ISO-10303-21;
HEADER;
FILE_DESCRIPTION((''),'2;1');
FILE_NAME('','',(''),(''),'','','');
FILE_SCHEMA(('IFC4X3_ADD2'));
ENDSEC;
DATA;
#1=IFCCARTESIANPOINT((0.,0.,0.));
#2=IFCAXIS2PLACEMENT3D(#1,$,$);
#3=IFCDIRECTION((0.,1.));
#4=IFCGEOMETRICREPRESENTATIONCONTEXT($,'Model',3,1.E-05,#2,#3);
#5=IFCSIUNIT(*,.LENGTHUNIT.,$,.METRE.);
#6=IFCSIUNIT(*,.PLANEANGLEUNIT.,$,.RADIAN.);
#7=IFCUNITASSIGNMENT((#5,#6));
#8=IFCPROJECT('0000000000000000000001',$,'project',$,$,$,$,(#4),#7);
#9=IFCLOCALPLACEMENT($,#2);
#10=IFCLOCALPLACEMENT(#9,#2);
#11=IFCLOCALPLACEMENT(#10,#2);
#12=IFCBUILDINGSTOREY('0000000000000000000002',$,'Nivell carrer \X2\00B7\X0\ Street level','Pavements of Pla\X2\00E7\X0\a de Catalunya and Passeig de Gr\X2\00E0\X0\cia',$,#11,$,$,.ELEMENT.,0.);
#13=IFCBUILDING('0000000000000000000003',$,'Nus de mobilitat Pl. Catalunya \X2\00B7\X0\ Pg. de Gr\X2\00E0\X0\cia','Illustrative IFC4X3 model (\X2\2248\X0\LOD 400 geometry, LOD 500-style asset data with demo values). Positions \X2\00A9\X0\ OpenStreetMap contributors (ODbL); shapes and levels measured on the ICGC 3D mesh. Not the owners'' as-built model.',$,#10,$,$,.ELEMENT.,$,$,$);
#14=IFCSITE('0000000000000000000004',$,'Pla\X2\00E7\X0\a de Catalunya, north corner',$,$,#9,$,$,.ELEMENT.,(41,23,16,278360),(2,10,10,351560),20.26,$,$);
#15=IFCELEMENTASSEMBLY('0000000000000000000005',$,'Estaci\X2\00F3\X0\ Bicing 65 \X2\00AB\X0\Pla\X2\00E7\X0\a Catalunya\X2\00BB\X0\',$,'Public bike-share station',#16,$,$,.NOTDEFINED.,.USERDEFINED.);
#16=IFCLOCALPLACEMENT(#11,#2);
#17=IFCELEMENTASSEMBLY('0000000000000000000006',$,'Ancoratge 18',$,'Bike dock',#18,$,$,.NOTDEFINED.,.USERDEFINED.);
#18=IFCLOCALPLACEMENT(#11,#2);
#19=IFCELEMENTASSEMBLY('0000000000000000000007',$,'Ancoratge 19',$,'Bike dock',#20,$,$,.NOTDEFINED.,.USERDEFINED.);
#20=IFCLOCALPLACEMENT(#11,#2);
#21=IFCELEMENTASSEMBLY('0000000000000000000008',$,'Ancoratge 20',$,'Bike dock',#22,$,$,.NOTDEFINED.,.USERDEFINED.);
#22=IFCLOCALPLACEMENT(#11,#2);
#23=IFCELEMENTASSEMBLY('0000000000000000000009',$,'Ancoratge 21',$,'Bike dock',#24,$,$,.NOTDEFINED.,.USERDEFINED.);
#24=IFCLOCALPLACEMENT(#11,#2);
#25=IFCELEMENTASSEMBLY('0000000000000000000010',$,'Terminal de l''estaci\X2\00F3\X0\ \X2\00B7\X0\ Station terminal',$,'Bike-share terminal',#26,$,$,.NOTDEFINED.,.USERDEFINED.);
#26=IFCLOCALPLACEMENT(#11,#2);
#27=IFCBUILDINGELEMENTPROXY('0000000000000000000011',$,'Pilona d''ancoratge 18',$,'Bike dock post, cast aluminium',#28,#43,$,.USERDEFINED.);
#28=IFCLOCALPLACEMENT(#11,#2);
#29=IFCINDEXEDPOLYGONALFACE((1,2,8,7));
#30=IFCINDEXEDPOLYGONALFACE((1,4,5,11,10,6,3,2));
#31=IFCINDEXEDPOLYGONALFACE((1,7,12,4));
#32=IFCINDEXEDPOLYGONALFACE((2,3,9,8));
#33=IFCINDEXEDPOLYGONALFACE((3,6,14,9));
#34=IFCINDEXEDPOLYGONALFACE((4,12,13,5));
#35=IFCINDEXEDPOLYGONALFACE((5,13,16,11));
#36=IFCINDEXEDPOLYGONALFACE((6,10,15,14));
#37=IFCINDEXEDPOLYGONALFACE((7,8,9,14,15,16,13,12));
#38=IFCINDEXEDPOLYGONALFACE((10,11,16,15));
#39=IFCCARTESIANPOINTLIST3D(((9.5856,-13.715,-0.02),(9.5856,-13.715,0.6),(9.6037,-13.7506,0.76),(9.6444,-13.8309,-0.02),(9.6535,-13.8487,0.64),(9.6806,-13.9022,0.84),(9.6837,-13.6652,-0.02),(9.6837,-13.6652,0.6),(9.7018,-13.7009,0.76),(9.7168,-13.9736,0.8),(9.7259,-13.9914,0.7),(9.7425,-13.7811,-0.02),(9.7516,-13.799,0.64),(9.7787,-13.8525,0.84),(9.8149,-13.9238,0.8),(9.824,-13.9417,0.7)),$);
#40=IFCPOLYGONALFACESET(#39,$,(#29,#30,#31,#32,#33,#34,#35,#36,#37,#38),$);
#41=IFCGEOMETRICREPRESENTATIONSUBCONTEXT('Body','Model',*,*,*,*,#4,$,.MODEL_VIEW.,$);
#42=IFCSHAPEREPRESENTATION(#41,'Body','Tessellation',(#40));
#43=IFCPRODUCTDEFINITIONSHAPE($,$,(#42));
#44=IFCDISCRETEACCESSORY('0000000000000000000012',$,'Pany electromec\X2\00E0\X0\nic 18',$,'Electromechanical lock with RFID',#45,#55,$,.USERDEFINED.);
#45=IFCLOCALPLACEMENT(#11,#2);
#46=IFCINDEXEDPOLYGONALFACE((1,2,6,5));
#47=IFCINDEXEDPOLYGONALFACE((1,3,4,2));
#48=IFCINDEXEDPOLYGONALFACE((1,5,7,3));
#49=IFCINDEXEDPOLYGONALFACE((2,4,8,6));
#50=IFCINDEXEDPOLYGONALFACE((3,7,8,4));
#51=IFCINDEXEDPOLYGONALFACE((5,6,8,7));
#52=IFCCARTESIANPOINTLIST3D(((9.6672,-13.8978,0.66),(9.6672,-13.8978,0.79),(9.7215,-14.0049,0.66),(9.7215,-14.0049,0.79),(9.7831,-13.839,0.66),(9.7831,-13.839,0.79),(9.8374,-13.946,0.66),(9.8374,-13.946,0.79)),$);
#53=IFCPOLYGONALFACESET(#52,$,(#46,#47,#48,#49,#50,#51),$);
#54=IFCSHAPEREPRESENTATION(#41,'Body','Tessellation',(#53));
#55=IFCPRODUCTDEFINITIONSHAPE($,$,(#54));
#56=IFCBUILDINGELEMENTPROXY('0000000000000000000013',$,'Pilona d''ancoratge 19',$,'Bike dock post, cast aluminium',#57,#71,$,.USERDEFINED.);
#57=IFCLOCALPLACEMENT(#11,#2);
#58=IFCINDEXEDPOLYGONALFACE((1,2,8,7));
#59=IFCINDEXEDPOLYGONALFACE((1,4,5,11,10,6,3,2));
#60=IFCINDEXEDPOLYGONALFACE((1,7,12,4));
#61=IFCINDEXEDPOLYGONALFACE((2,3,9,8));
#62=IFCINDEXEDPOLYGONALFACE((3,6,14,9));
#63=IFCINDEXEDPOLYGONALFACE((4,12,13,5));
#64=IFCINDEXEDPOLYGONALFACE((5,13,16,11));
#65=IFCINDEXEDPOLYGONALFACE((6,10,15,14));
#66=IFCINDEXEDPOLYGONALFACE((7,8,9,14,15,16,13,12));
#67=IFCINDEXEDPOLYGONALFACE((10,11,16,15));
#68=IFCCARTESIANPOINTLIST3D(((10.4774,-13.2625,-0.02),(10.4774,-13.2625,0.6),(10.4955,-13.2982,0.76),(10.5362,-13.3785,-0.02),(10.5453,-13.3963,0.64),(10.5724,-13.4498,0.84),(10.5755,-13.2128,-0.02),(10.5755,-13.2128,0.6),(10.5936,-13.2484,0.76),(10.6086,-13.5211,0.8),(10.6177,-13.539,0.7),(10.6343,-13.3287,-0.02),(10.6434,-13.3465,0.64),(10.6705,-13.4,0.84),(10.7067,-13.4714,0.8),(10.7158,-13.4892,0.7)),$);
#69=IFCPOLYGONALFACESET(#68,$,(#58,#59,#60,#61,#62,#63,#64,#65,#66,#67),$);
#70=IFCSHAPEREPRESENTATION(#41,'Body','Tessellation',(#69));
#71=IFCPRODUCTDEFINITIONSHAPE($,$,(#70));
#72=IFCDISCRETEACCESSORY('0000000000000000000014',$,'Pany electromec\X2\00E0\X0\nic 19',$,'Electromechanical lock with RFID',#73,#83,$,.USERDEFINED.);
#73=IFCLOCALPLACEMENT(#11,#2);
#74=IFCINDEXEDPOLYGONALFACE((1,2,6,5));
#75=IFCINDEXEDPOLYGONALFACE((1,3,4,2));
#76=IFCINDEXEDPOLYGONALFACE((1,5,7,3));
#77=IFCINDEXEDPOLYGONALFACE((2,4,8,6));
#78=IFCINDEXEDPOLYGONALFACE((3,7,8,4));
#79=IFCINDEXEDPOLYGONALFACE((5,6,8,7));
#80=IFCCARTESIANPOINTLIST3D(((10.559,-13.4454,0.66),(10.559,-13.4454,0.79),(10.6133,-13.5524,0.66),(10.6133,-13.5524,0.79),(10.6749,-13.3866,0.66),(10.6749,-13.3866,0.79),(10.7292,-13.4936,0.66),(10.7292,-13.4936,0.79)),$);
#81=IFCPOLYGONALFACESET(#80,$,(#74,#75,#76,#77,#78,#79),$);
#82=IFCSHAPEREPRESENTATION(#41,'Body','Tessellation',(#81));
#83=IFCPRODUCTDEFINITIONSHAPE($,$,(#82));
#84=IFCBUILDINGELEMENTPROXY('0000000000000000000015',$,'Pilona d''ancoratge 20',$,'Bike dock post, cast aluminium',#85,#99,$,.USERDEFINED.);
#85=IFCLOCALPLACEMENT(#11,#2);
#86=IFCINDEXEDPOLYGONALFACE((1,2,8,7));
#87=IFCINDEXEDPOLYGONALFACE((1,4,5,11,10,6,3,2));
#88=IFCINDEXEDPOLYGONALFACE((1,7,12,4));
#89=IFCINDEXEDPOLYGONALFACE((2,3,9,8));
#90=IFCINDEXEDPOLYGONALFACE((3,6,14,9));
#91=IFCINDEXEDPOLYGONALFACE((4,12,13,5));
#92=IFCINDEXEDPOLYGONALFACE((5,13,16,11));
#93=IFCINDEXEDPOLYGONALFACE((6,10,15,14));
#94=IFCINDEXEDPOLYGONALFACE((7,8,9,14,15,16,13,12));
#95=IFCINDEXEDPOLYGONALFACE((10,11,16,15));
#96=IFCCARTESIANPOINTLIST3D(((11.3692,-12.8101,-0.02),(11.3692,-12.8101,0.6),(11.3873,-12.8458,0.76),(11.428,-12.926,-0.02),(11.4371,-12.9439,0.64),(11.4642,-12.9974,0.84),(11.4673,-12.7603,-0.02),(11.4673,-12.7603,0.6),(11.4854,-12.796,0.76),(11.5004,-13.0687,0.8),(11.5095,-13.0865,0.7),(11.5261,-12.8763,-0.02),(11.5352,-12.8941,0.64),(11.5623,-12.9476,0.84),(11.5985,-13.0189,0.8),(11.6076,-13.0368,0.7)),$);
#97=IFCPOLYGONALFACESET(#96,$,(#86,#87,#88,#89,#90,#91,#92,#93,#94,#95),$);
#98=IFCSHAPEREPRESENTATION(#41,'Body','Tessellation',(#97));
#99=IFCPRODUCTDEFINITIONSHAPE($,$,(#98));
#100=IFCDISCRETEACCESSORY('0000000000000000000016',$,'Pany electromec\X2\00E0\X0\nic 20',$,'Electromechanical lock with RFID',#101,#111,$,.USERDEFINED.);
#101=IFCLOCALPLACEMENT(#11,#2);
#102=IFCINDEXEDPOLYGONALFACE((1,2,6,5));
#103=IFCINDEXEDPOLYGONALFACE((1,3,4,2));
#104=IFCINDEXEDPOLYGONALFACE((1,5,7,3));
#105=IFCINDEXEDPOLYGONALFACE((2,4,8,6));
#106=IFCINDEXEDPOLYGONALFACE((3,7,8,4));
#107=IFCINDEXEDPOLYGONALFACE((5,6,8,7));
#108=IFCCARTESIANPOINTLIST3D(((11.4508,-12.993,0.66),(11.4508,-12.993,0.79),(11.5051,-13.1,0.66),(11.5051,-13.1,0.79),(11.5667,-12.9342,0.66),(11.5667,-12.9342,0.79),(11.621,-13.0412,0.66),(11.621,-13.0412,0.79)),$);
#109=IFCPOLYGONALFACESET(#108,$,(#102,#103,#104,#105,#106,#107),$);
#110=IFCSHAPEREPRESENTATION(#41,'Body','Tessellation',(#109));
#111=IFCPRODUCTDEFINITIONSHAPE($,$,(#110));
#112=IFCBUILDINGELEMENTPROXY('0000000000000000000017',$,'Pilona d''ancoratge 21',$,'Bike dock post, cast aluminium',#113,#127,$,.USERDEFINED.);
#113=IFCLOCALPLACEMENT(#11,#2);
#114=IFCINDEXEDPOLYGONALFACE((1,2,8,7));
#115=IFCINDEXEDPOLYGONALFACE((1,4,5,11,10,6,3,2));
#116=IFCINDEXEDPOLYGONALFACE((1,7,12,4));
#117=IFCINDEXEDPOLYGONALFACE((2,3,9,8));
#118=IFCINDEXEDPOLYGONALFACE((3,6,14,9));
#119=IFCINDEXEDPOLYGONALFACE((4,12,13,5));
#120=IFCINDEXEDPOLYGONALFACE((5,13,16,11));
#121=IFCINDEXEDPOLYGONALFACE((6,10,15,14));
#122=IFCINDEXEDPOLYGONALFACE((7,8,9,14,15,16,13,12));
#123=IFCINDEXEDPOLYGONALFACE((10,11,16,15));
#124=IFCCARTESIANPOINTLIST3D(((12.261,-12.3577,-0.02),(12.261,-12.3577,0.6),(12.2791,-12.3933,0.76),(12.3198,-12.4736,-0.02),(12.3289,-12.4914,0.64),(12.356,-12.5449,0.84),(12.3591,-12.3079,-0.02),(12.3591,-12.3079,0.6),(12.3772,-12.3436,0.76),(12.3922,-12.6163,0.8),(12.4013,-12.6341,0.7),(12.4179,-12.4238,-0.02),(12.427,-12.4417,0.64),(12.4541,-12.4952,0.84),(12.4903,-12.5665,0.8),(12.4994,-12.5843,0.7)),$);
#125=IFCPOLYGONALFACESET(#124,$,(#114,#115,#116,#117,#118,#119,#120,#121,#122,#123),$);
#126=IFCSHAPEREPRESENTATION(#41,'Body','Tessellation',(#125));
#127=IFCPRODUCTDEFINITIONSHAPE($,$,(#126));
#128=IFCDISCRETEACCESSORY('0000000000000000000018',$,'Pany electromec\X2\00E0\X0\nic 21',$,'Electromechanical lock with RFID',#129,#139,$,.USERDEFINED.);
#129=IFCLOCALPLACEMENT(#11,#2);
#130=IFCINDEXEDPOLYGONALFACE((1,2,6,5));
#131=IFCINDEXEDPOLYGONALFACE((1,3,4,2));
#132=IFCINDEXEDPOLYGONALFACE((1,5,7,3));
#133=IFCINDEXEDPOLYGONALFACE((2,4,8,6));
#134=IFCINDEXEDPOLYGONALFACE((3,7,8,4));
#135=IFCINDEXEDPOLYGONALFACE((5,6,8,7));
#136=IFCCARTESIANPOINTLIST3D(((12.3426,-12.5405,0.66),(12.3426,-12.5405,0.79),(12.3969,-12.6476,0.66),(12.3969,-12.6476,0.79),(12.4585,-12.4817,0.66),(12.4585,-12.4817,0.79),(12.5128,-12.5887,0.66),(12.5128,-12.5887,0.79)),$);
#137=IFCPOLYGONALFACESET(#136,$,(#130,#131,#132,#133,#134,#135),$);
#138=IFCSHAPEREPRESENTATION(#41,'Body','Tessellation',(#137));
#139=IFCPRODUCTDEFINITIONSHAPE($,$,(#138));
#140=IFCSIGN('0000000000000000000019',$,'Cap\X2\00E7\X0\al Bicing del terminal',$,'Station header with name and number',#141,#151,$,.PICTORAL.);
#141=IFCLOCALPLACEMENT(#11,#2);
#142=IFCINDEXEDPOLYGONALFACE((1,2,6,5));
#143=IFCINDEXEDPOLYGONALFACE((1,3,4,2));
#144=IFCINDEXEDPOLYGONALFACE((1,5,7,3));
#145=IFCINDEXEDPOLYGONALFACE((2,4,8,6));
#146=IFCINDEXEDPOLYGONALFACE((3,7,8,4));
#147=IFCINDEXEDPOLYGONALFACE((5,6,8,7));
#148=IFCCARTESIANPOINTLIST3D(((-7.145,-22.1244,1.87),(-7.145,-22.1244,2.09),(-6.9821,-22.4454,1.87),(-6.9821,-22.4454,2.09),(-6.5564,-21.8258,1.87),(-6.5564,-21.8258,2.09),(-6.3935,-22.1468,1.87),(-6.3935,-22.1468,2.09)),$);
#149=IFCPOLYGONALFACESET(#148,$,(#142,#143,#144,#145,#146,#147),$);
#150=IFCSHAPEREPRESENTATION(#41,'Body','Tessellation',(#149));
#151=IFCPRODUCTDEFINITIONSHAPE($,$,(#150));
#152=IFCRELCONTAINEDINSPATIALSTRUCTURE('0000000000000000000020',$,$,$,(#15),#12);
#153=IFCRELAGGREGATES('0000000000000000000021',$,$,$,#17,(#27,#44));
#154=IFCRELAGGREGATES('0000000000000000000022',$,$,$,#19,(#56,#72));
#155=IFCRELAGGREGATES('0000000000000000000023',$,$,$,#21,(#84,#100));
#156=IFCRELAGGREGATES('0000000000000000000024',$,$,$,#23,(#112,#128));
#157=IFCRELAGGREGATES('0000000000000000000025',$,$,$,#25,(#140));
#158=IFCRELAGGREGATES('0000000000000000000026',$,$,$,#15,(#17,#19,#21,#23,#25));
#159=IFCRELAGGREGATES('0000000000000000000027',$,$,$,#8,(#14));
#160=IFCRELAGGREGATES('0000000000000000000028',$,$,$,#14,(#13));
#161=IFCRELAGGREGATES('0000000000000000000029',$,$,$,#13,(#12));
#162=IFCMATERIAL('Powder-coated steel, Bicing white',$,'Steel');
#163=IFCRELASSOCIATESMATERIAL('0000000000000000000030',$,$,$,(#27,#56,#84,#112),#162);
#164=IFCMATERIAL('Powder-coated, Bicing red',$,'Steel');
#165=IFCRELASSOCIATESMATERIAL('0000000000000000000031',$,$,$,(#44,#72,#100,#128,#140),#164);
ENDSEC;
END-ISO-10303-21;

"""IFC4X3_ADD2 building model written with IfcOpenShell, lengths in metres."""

from ifc_helpers import new_model, si_unit, direction, frame, frame_2d, origin, place, context, subcontext, project, spatial, polyline, rectangle, outline, extrude, material, element, aggregate, save


model = new_model("IFC4X3_ADD2")

# Units and contexts
model_context = context("Model", 3, precision=1e-05, world=origin(), true_north=direction((0.0, 1.0)))
body_context = subcontext(model_context, "Body", "Model", "MODEL_VIEW")
ifc_project = project(units=[si_unit("LENGTHUNIT", "METRE"), si_unit("PLANEANGLEUNIT", "RADIAN")], contexts=[model_context])

# Site, building, storey
site_placement = place(None, origin())
site = spatial("IfcSite", under=ifc_project, at=site_placement, Name="Plaça de Catalunya, north corner", CompositionType="ELEMENT", RefLatitude=(41, 23, 16, 278360), RefLongitude=(2, 10, 10, 351560), RefElevation=20.26)
building_placement = place(site_placement, origin())
building = spatial("IfcBuilding", under=site, at=building_placement, Name="Nus de mobilitat Pl. Catalunya · Pg. de Gràcia", Description="Illustrative IFC4X3 model (≈LOD 400 geometry, LOD 500-style asset data with demo values). Positions © OpenStreetMap contributors (ODbL); shapes and levels measured on the ICGC 3D mesh. Not the owners' as-built model.", CompositionType="ELEMENT")
storey_placement = place(building_placement, origin())
storey = spatial("IfcBuildingStorey", under=building, at=storey_placement, Name="Nivell carrer · Street level", Description="Pavements of Plaça de Catalunya and Passeig de Gràcia", CompositionType="ELEMENT", Elevation=0.0)

# Element assemblies, building element proxies, discrete accessories, sign
assembly_1_placement = place(building_placement, origin())
assembly_1 = element("IfcElementAssembly", 1, at=assembly_1_placement, inside=storey, Name="Estació Bicing 65 «Plaça Catalunya»", ObjectType="Public bike-share station", AssemblyPlace="NOTDEFINED", PredefinedType="USERDEFINED")
assembly_2_placement = place(building_placement, origin())
assembly_2 = element("IfcElementAssembly", 2, at=assembly_2_placement, Name="Ancoratge 18", ObjectType="Bike dock", AssemblyPlace="NOTDEFINED", PredefinedType="USERDEFINED")
assembly_3_placement = place(building_placement, origin())
assembly_3 = element("IfcElementAssembly", 3, at=assembly_3_placement, Name="Ancoratge 19", ObjectType="Bike dock", AssemblyPlace="NOTDEFINED", PredefinedType="USERDEFINED")
assembly_4_placement = place(building_placement, origin())
assembly_4 = element("IfcElementAssembly", 4, at=assembly_4_placement, Name="Ancoratge 20", ObjectType="Bike dock", AssemblyPlace="NOTDEFINED", PredefinedType="USERDEFINED")
assembly_5_placement = place(building_placement, origin())
assembly_5 = element("IfcElementAssembly", 5, at=assembly_5_placement, Name="Ancoratge 21", ObjectType="Bike dock", AssemblyPlace="NOTDEFINED", PredefinedType="USERDEFINED")
assembly_6_placement = place(building_placement, origin())
assembly_6 = element("IfcElementAssembly", 6, at=assembly_6_placement, Name="Terminal de l'estació · Station terminal", ObjectType="Bike-share terminal", AssemblyPlace="NOTDEFINED", PredefinedType="USERDEFINED")
ifc_material_1 = material(Name="Powder-coated steel, Bicing white", Category="Steel")
ifc_material_2 = material(Name="Powder-coated, Bicing red", Category="Steel")
proxy_1_placement = place(building_placement, origin())
proxy_1 = element("IfcBuildingElementProxy", 7, at=proxy_1_placement, material=ifc_material_1, Name="Pilona d'ancoratge 18", ObjectType="Bike dock post, cast aluminium", PredefinedType="USERDEFINED", context=body_context, shape_type="SweptSolid", body=[
    extrude(outline(polyline([(0.07, 0.06), (0.07, 0.68), (0.03, 0.84), (-0.14, 0.92), (-0.22, 0.88), (-0.24, 0.78), (-0.08, 0.72), (-0.06, 0.06), (0.07, 0.06)])), frame((9.6173, -13.7774, -0.08), z_axis=(0.891798, 0.452435, 0.0), x_axis=(-0.452435, 0.891798, 0.0)), (0.0, 0.0, 1.0), 0.11),
])
discrete_accessory_1_placement = place(building_placement, origin())
discrete_accessory_1 = element("IfcDiscreteAccessory", 8, at=discrete_accessory_1_placement, material=ifc_material_2, Name="Pany electromecànic 18", ObjectType="Electromechanical lock with RFID", PredefinedType="USERDEFINED", context=body_context, shape_type="SweptSolid", body=[
    extrude(rectangle(XDim=0.13, YDim=0.12, at=frame_2d((0.0, 0.0), x_axis=(0.891798, 0.452435))), frame((9.7523, -13.9219, 0.66)), (0.0, 0.0, 1.0), 0.13),
])
aggregate(assembly_2, [proxy_1, discrete_accessory_1])
proxy_2_placement = place(building_placement, origin())
proxy_2 = element("IfcBuildingElementProxy", 9, at=proxy_2_placement, material=ifc_material_1, Name="Pilona d'ancoratge 19", ObjectType="Bike dock post, cast aluminium", PredefinedType="USERDEFINED", context=body_context, shape_type="SweptSolid", body=[
    extrude(outline(polyline([(0.07, 0.06), (0.07, 0.68), (0.03, 0.84), (-0.14, 0.92), (-0.22, 0.88), (-0.24, 0.78), (-0.08, 0.72), (-0.06, 0.06), (0.07, 0.06)])), frame((10.5091, -13.325, -0.08), z_axis=(0.891798, 0.452435, 0.0), x_axis=(-0.452435, 0.891798, 0.0)), (0.0, 0.0, 1.0), 0.11),
])
discrete_accessory_2_placement = place(building_placement, origin())
discrete_accessory_2 = element("IfcDiscreteAccessory", 10, at=discrete_accessory_2_placement, material=ifc_material_2, Name="Pany electromecànic 19", ObjectType="Electromechanical lock with RFID", PredefinedType="USERDEFINED", context=body_context, shape_type="SweptSolid", body=[
    extrude(rectangle(XDim=0.13, YDim=0.12, at=frame_2d((0.0, 0.0), x_axis=(0.891798, 0.452435))), frame((10.6441, -13.4695, 0.66)), (0.0, 0.0, 1.0), 0.13),
])
aggregate(assembly_3, [proxy_2, discrete_accessory_2])
proxy_3_placement = place(building_placement, origin())
proxy_3 = element("IfcBuildingElementProxy", 11, at=proxy_3_placement, material=ifc_material_1, Name="Pilona d'ancoratge 20", ObjectType="Bike dock post, cast aluminium", PredefinedType="USERDEFINED", context=body_context, shape_type="SweptSolid", body=[
    extrude(outline(polyline([(0.07, 0.06), (0.07, 0.68), (0.03, 0.84), (-0.14, 0.92), (-0.22, 0.88), (-0.24, 0.78), (-0.08, 0.72), (-0.06, 0.06), (0.07, 0.06)])), frame((11.4009, -12.8725, -0.08), z_axis=(0.891798, 0.452435, 0.0), x_axis=(-0.452435, 0.891798, 0.0)), (0.0, 0.0, 1.0), 0.11),
])
discrete_accessory_3_placement = place(building_placement, origin())
discrete_accessory_3 = element("IfcDiscreteAccessory", 12, at=discrete_accessory_3_placement, material=ifc_material_2, Name="Pany electromecànic 20", ObjectType="Electromechanical lock with RFID", PredefinedType="USERDEFINED", context=body_context, shape_type="SweptSolid", body=[
    extrude(rectangle(XDim=0.13, YDim=0.12, at=frame_2d((0.0, 0.0), x_axis=(0.891798, 0.452435))), frame((11.5359, -13.0171, 0.66)), (0.0, 0.0, 1.0), 0.13),
])
aggregate(assembly_4, [proxy_3, discrete_accessory_3])
proxy_4_placement = place(building_placement, origin())
proxy_4 = element("IfcBuildingElementProxy", 13, at=proxy_4_placement, material=ifc_material_1, Name="Pilona d'ancoratge 21", ObjectType="Bike dock post, cast aluminium", PredefinedType="USERDEFINED", context=body_context, shape_type="SweptSolid", body=[
    extrude(outline(polyline([(0.07, 0.06), (0.07, 0.68), (0.03, 0.84), (-0.14, 0.92), (-0.22, 0.88), (-0.24, 0.78), (-0.08, 0.72), (-0.06, 0.06), (0.07, 0.06)])), frame((12.2927, -12.4201, -0.08), z_axis=(0.891798, 0.452435, 0.0), x_axis=(-0.452435, 0.891798, 0.0)), (0.0, 0.0, 1.0), 0.11),
])
discrete_accessory_4_placement = place(building_placement, origin())
discrete_accessory_4 = element("IfcDiscreteAccessory", 14, at=discrete_accessory_4_placement, material=ifc_material_2, Name="Pany electromecànic 21", ObjectType="Electromechanical lock with RFID", PredefinedType="USERDEFINED", context=body_context, shape_type="SweptSolid", body=[
    extrude(rectangle(XDim=0.13, YDim=0.12, at=frame_2d((0.0, 0.0), x_axis=(0.891798, 0.452435))), frame((12.4277, -12.5646, 0.66)), (0.0, 0.0, 1.0), 0.13),
])
aggregate(assembly_5, [proxy_4, discrete_accessory_4])
sign_placement = place(building_placement, origin())
sign = element("IfcSign", 15, at=sign_placement, material=ifc_material_2, Name="Capçal Bicing del terminal", ObjectType="Station header with name and number", PredefinedType="PICTORAL", context=body_context, shape_type="SweptSolid", body=[
    extrude(rectangle(XDim=0.66, YDim=0.36, at=frame_2d((0.0, 0.0), x_axis=(0.891798, 0.452435))), frame((-6.7692, -22.1356, 1.87)), (0.0, 0.0, 1.0), 0.22),
])
aggregate(assembly_6, [sign])
aggregate(assembly_1, [assembly_2, assembly_3, assembly_4, assembly_5, assembly_6])

save(model, "model.ifc")
